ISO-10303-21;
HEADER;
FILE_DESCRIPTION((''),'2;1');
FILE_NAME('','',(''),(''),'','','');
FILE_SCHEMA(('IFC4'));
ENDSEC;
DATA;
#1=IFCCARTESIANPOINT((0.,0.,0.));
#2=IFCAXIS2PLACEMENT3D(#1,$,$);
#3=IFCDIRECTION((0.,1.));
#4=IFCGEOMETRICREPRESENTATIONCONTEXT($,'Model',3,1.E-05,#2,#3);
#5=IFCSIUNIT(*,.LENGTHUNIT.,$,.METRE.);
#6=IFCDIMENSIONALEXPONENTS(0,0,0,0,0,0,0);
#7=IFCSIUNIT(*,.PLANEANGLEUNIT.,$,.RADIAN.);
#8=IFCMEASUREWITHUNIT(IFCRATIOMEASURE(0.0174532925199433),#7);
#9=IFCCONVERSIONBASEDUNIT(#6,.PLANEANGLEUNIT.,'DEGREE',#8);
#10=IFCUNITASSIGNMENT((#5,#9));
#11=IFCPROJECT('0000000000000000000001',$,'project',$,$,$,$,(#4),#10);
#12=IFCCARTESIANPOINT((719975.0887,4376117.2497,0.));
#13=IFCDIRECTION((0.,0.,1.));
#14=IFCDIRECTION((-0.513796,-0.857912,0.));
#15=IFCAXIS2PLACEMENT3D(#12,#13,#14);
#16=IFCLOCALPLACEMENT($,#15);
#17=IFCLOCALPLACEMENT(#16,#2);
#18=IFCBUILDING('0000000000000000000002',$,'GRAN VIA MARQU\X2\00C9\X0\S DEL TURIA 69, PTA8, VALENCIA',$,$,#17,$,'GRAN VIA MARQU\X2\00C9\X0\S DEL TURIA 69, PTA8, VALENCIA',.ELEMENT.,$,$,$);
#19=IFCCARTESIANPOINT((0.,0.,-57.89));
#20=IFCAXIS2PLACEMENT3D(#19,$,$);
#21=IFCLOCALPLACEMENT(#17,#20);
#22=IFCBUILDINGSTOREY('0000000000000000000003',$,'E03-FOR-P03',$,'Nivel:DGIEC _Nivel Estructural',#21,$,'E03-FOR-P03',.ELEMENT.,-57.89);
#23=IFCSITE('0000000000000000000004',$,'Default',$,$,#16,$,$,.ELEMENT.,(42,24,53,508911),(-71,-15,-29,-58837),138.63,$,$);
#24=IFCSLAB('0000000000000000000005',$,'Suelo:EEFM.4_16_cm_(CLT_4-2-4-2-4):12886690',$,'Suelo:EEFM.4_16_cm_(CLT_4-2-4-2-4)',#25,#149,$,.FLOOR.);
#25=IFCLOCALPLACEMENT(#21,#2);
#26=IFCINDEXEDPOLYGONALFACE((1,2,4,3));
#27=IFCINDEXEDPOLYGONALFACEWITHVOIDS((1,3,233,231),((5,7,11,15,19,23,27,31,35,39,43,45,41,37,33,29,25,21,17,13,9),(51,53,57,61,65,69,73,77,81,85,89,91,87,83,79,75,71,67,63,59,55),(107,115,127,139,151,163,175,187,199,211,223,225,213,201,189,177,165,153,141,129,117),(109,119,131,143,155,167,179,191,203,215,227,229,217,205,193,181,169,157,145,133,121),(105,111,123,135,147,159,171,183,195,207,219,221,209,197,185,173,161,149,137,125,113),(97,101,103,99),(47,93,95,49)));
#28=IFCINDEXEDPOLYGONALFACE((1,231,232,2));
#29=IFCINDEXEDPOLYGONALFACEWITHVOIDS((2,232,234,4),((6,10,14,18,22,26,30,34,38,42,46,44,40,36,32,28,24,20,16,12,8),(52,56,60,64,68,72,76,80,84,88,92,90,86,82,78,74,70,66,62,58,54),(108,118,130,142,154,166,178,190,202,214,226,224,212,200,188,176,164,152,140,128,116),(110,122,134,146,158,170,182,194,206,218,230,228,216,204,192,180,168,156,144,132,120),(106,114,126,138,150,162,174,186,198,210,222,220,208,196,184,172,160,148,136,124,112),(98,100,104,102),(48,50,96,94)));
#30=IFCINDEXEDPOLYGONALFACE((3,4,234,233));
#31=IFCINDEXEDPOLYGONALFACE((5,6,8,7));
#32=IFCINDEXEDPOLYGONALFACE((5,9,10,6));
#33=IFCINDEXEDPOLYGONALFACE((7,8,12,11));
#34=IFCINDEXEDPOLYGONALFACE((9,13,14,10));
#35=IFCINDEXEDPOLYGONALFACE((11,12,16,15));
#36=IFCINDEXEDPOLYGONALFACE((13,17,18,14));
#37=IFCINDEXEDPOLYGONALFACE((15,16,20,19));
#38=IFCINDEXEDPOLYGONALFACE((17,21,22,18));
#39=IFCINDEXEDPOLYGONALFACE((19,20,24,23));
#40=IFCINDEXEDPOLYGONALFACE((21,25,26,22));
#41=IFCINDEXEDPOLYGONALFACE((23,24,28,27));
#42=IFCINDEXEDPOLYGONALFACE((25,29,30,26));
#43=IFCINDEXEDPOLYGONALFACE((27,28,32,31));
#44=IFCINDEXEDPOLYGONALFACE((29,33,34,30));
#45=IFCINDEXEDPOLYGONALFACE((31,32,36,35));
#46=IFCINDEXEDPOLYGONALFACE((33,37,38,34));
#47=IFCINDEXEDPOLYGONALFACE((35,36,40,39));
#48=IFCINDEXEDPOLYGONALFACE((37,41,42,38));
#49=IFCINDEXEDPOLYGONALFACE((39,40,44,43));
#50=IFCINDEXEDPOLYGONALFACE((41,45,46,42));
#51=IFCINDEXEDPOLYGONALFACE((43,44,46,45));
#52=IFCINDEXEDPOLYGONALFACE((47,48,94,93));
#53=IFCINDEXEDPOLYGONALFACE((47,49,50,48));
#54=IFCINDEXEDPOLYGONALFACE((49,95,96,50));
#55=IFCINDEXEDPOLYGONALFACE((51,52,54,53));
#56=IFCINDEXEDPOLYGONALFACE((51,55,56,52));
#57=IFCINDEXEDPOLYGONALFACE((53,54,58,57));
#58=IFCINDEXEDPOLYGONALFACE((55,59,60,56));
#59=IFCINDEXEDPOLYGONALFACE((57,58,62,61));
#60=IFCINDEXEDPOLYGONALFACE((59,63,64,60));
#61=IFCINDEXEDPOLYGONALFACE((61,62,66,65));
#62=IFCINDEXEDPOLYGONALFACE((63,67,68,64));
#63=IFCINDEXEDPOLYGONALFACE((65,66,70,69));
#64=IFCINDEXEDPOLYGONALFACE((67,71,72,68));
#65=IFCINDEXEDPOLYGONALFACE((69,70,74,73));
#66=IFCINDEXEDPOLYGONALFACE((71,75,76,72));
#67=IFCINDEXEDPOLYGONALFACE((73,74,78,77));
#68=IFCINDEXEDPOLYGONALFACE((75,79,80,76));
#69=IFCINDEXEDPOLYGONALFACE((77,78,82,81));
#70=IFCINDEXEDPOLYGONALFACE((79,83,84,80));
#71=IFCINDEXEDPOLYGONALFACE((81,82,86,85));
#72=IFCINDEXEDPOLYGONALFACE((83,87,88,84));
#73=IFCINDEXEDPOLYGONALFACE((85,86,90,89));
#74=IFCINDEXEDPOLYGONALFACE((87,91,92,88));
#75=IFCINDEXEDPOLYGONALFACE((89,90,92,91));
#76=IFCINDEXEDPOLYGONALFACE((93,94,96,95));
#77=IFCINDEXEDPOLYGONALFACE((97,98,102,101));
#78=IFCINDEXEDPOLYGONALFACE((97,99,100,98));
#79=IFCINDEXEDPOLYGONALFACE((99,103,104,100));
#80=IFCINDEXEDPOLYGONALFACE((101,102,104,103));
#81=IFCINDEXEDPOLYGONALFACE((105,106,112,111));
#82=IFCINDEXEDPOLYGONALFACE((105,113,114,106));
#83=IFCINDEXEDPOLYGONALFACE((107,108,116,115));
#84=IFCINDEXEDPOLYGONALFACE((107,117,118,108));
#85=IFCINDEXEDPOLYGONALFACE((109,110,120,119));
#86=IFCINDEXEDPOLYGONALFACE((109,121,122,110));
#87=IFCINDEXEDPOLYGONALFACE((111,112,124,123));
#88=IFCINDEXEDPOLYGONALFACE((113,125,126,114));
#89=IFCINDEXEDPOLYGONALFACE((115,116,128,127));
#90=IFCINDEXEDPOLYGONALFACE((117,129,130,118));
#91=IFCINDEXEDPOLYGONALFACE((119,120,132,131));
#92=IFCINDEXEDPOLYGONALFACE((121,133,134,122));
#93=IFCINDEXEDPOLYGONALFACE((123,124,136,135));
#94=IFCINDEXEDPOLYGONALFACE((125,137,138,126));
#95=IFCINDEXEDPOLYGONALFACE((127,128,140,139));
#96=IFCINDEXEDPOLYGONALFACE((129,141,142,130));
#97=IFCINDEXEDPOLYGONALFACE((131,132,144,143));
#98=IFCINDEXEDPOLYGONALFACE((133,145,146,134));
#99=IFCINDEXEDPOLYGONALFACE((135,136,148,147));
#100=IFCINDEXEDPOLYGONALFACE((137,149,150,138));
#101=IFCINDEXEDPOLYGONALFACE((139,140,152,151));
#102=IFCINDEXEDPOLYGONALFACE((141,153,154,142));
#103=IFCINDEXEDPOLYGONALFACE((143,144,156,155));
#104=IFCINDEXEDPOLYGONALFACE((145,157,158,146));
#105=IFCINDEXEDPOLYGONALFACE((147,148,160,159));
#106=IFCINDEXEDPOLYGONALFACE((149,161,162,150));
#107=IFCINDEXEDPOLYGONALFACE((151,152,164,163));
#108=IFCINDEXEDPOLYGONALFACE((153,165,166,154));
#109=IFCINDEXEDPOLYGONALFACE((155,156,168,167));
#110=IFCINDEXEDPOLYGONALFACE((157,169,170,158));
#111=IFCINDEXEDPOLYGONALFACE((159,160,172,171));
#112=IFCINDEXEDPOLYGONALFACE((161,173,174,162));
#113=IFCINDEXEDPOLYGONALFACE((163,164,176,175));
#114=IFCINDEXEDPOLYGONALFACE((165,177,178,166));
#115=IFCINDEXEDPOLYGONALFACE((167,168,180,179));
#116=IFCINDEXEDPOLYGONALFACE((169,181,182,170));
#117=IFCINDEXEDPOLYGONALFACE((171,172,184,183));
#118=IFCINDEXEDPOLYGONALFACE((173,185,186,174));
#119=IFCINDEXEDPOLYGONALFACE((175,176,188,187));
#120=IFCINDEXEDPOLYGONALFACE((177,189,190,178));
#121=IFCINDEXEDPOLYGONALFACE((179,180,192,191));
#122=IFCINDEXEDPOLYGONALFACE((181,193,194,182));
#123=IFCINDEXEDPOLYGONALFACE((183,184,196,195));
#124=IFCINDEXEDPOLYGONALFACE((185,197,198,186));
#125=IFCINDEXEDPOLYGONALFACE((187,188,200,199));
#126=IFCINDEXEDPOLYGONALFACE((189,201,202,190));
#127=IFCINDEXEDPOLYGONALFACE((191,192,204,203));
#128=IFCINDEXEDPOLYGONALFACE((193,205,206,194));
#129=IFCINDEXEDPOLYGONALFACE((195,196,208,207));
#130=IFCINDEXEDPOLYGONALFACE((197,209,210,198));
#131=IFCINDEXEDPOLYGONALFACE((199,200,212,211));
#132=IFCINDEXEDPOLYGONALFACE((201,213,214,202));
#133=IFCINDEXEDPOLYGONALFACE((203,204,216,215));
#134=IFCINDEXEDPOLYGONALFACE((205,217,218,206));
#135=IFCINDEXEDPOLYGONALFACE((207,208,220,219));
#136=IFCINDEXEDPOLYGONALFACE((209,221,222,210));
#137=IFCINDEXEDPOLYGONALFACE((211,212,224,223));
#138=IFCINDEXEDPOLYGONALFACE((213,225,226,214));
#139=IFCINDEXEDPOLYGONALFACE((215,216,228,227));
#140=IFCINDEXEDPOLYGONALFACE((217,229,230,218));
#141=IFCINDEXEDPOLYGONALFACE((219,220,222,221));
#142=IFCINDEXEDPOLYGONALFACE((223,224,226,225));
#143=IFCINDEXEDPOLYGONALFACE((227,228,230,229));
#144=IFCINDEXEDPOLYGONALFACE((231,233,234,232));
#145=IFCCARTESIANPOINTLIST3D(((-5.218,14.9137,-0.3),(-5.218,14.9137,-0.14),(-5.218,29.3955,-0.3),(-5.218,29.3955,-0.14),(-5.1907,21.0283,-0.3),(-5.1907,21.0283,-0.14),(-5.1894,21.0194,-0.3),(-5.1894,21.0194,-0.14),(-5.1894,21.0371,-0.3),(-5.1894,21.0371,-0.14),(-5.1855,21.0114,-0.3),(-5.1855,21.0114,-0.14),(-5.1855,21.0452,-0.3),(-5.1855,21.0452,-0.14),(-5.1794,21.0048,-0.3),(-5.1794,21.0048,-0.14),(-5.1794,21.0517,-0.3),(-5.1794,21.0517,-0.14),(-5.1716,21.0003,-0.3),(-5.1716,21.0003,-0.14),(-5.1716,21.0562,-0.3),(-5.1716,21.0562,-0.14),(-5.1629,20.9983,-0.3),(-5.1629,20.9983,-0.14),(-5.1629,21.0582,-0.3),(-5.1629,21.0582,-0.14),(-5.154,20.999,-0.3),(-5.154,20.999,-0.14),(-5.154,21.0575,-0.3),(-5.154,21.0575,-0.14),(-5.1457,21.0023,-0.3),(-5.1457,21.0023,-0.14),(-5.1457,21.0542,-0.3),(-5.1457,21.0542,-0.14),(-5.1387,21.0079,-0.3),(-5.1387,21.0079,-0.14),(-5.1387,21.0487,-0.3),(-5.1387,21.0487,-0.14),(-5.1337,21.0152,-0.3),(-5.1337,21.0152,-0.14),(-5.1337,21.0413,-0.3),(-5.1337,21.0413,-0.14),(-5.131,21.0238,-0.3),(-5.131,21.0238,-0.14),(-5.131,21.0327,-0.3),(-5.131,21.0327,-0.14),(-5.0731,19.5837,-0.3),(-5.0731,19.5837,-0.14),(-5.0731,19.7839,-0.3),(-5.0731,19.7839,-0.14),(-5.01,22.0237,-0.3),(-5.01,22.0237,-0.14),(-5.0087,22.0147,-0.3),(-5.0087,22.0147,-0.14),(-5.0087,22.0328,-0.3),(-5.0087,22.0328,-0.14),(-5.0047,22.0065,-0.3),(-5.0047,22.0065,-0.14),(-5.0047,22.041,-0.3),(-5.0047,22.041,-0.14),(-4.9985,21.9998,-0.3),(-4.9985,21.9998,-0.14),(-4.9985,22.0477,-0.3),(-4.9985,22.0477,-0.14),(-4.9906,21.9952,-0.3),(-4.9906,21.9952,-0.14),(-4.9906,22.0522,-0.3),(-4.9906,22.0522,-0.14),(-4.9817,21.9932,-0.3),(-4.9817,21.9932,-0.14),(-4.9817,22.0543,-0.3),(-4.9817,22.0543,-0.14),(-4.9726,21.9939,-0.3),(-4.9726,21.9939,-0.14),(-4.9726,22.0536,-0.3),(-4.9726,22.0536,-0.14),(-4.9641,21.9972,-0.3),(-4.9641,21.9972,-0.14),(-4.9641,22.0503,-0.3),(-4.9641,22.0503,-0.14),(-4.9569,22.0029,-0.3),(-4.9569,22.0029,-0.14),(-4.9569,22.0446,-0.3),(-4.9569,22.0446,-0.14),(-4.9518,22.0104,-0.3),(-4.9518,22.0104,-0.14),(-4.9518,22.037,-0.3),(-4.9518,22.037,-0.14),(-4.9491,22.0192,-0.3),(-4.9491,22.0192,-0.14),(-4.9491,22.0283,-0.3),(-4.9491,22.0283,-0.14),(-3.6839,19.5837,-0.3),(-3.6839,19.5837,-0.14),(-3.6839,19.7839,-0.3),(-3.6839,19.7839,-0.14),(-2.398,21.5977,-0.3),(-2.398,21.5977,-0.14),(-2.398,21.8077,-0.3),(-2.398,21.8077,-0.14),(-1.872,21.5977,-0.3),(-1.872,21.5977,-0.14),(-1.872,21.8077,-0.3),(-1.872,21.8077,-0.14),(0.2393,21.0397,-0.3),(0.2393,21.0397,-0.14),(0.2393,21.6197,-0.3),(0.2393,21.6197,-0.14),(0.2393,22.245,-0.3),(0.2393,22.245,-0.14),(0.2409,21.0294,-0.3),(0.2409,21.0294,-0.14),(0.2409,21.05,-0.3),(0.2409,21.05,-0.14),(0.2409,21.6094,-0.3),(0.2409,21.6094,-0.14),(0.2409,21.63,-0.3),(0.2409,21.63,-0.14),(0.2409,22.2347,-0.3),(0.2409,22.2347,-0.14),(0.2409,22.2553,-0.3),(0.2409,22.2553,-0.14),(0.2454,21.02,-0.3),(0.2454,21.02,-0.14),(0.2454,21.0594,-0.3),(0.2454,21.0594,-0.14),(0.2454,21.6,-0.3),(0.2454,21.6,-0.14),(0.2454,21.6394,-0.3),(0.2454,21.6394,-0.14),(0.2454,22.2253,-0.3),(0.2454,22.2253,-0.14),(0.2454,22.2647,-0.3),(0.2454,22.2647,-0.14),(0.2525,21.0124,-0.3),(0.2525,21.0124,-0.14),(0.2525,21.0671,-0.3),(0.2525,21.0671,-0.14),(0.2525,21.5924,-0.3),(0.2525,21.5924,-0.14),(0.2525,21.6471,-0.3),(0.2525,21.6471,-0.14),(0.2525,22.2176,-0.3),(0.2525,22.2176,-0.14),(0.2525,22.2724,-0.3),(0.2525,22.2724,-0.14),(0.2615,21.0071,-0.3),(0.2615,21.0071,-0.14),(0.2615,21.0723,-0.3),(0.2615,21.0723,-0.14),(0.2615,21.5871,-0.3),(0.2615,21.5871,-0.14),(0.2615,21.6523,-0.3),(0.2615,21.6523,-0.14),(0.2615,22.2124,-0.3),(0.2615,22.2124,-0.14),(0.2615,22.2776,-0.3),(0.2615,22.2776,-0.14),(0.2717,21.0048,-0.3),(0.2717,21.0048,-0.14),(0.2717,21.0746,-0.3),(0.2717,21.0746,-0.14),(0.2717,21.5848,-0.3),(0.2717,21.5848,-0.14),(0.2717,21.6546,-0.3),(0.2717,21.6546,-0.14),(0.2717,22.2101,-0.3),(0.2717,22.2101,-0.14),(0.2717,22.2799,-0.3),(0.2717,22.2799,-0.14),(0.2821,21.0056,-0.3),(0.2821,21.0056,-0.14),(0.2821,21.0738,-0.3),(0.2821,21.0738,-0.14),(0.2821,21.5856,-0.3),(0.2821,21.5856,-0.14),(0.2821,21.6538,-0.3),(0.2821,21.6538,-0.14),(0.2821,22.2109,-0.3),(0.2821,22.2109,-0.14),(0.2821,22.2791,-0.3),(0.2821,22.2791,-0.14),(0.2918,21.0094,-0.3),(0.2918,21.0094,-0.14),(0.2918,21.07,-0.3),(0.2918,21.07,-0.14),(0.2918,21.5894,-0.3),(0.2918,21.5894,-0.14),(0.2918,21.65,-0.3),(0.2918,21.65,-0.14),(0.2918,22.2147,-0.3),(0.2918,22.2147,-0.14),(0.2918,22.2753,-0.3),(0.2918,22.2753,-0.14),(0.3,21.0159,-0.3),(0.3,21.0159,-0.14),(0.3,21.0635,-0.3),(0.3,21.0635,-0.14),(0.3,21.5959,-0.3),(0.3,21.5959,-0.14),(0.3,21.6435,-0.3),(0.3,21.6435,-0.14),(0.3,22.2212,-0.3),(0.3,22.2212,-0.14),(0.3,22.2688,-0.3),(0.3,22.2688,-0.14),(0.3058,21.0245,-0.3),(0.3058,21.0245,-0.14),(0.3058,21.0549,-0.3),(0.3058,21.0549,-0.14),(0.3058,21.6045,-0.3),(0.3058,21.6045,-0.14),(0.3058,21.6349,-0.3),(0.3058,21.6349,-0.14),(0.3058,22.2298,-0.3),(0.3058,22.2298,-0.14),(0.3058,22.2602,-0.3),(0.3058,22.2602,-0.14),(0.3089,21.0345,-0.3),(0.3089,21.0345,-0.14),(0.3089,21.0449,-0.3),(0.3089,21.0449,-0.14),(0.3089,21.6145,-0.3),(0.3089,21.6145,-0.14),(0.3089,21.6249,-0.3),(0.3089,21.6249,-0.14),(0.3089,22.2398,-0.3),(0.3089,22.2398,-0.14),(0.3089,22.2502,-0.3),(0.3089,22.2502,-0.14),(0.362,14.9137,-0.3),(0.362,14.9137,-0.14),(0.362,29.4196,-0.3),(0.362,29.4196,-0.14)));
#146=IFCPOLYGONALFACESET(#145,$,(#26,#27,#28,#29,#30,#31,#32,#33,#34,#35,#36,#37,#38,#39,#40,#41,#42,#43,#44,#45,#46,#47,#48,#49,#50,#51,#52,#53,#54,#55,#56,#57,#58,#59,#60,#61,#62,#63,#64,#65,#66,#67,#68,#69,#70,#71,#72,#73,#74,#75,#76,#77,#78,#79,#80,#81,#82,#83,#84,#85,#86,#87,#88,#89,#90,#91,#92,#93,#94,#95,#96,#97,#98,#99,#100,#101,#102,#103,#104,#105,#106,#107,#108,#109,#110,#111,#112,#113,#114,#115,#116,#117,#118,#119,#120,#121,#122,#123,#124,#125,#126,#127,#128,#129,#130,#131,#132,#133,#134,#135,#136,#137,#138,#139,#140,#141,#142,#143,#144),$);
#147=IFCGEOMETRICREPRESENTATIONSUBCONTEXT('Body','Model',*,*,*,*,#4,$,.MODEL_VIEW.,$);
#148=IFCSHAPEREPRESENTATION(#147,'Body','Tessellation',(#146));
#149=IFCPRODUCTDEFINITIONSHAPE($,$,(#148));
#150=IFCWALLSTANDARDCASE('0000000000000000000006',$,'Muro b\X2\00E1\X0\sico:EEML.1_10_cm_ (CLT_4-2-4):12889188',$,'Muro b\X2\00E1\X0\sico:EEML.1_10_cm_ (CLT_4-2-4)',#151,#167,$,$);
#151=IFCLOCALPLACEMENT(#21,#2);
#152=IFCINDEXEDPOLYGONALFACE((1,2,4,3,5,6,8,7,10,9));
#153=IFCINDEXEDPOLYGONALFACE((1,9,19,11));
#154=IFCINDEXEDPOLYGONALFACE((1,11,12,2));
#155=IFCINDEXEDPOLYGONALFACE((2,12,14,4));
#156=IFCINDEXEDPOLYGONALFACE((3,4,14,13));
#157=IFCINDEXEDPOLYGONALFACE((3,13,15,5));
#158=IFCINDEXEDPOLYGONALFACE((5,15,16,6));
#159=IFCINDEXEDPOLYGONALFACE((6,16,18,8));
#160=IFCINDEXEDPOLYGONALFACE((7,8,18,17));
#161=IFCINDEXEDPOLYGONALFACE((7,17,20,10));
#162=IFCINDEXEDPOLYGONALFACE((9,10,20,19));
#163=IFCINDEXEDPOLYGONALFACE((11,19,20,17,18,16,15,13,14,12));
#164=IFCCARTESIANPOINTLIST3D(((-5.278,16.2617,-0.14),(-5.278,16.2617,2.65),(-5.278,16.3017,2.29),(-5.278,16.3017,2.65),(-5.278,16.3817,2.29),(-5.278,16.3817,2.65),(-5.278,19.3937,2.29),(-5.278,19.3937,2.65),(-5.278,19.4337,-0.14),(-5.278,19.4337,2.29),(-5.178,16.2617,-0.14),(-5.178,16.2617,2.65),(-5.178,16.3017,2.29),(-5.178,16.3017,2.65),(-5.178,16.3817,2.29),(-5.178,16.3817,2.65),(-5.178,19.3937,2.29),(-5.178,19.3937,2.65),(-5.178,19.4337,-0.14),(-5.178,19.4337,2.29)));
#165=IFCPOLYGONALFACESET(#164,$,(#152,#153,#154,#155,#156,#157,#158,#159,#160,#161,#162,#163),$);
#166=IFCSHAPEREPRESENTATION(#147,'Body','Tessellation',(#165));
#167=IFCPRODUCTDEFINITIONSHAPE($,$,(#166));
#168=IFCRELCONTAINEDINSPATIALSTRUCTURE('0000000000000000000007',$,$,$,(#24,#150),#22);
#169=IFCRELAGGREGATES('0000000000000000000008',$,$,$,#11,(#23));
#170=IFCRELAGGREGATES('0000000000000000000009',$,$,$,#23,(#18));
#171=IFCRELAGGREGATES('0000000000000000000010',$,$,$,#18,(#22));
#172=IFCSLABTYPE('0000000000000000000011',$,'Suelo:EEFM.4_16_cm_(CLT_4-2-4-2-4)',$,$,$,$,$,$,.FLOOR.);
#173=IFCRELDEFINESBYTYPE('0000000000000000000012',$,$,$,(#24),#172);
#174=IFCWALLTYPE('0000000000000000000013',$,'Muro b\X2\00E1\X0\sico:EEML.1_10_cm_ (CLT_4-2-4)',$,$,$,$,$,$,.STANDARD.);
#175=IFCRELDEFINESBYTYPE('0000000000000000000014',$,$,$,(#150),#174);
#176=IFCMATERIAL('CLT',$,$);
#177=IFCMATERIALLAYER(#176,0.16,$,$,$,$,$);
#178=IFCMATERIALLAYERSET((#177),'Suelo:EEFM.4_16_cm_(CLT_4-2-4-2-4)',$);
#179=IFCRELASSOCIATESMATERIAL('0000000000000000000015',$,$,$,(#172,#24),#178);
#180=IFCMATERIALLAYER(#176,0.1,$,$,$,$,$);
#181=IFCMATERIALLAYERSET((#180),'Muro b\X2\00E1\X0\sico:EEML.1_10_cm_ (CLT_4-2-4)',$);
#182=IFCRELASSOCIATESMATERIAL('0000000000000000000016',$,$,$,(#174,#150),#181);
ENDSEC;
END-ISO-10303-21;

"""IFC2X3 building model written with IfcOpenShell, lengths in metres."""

from ifc_helpers import new_model, entity, si_unit, converted_unit, direction, frame, frame_2d, origin, origin_2d_with_axis, place, context, subcontext, project, spatial, polyline, rectangle, circle, outline, extrude, material, layer, layer_set, layer_usage, type_object, element, save


model = new_model("IFC2X3")

# Units and contexts
model_context = context("Model", 3, precision=1e-05, world=origin(), true_north=direction((0.0, 1.0)))
body_context = subcontext(model_context, "Body", "Model", "MODEL_VIEW")
ifc_project = project(units=[si_unit("LENGTHUNIT", "METRE"), converted_unit("PLANEANGLEUNIT", "DEGREE", entity("IfcRatioMeasure", 0.0174532925199433), si_unit("PLANEANGLEUNIT", "RADIAN"), dimensions=[0, 0, 0, 0, 0, 0, 0])], contexts=[model_context])

# Site, building, storey
site_placement = place(None, frame((719975.0887, 4376117.2497, 0.0), z_axis=(0.0, 0.0, 1.0), x_axis=(-0.513796, -0.857912, 0.0)))
site = spatial("IfcSite", under=ifc_project, at=site_placement, Name="Default", CompositionType="ELEMENT", RefLatitude=(42, 24, 53, 508911), RefLongitude=(-71, -15, -29, -58837), RefElevation=138.63)
building_placement = place(site_placement, origin())
building = spatial("IfcBuilding", under=site, at=building_placement, Name="GRAN VIA MARQUÉS DEL TURIA 69, PTA8, VALENCIA", LongName="GRAN VIA MARQUÉS DEL TURIA 69, PTA8, VALENCIA", CompositionType="ELEMENT")
storey_placement = place(building_placement, frame((0.0, 0.0, -57.89)))
storey = spatial("IfcBuildingStorey", under=building, at=storey_placement, Name="E03-FOR-P03", ObjectType="Nivel:DGIEC _Nivel Estructural", LongName="E03-FOR-P03", CompositionType="ELEMENT", Elevation=-57.89)

# Slab, openings
ifc_material = material(Name="CLT")
ifc_layer_1 = layer(ifc_material, 0.16)
ifc_layer_set_1 = layer_set([ifc_layer_1], Name="Suelo:EEFM.4_16_cm_(CLT_4-2-4-2-4)")
ifc_layer_usage_1 = layer_usage(ifc_layer_set_1, "AXIS3", "POSITIVE", 0.0)
slab_type_1 = type_object("IfcSlabType", Name="Suelo:EEFM.4_16_cm_(CLT_4-2-4-2-4)", PredefinedType="FLOOR", material=ifc_layer_set_1)
slab_1_placement = place(storey_placement, frame((-5.218, 14.9137, -0.3)))
slab_1 = element("IfcSlab", 1, at=slab_1_placement, inside=storey, type_object=slab_type_1, material=ifc_layer_usage_1, Name="Suelo:EEFM.4_16_cm_(CLT_4-2-4-2-4):12886690", ObjectType="Suelo:EEFM.4_16_cm_(CLT_4-2-4-2-4)", PredefinedType="FLOOR", context=body_context, shape_type="SweptSolid", body=[
    extrude(outline(polyline([(-2.79, 7.2529), (-2.79, -7.2529), (2.79, -7.2529), (2.79, 7.2288), (-2.79, 7.2529)])), frame((2.79, 7.2529, 0.16), z_axis=(0.0, 0.0, -1.0), x_axis=(-1.0, 0.0, 0.0)), (0.0, 0.0, 1.0), 0.16),
])
opening_1_placement = place(storey_placement, frame((-5.218, 14.9137, -0.3)))
element("IfcOpeningElement", 2, at=opening_1_placement, cuts=slab_1, ObjectType="Opening", context=body_context, shape_type="SweptSolid", body=[
    extrude(rectangle(XDim=0.2002, YDim=1.3893, at=frame_2d((1.9505, -2.4829), x_axis=(0.0, -1.0))), frame((2.79, 7.2529, 0.16), z_axis=(0.0, 0.0, -1.0), x_axis=(-1.0, 0.0, 0.0)), (0.0, 0.0, 1.0), 0.16),
])
opening_2_placement = place(storey_placement, frame((-5.218, 14.9137, -0.3)))
element("IfcOpeningElement", 3, at=opening_2_placement, cuts=slab_1, ObjectType="Opening", context=body_context, shape_type="SweptSolid", body=[
    extrude(rectangle(XDim=0.21, YDim=0.5259, at=frame_2d((-0.293, -0.4639), x_axis=(0.0, -1.0))), frame((2.79, 7.2529, 0.16), z_axis=(0.0, 0.0, -1.0), x_axis=(-1.0, 0.0, 0.0)), (0.0, 0.0, 1.0), 0.16),
])
opening_3_placement = place(storey_placement, frame((-5.218, 14.9137, -0.3)))
element("IfcOpeningElement", 4, at=opening_3_placement, cuts=slab_1, ObjectType="Opening", context=body_context, shape_type="SweptSolid", body=[
    extrude(circle(Radius=0.03, at=frame_2d((2.7326, -1.1384), x_axis=(1.0, 0.0))), frame((2.79, 7.2529, 0.16), z_axis=(0.0, 0.0, -1.0), x_axis=(-1.0, 0.0, 0.0)), (0.0, 0.0, 1.0), 0.16),
])
opening_4_placement = place(storey_placement, frame((-5.218, 14.9137, -0.3)))
element("IfcOpeningElement", 5, at=opening_4_placement, cuts=slab_1, ObjectType="Opening", context=body_context, shape_type="SweptSolid", body=[
    extrude(circle(Radius=0.035, at=frame_2d((-2.7024, 0.0784), x_axis=(1.0, 0.0))), frame((2.79, 7.2529, 0.16), z_axis=(0.0, 0.0, -1.0), x_axis=(-1.0, 0.0, 0.0)), (0.0, 0.0, 1.0), 0.16),
])
opening_5_placement = place(storey_placement, frame((-5.218, 14.9137, -0.3)))
element("IfcOpeningElement", 6, at=opening_5_placement, cuts=slab_1, ObjectType="Opening", context=body_context, shape_type="SweptSolid", body=[
    extrude(circle(Radius=0.035, at=frame_2d((-2.7024, -0.5469), x_axis=(1.0, 0.0))), frame((2.79, 7.2529, 0.16), z_axis=(0.0, 0.0, -1.0), x_axis=(-1.0, 0.0, 0.0)), (0.0, 0.0, 1.0), 0.16),
])
opening_6_placement = place(storey_placement, frame((-5.218, 14.9137, -0.3)))
element("IfcOpeningElement", 7, at=opening_6_placement, cuts=slab_1, ObjectType="Opening", context=body_context, shape_type="SweptSolid", body=[
    extrude(circle(Radius=0.035, at=frame_2d((-2.7024, -1.1269), x_axis=(1.0, 0.0))), frame((2.79, 7.2529, 0.16), z_axis=(0.0, 0.0, -1.0), x_axis=(-1.0, 0.0, 0.0)), (0.0, 0.0, 1.0), 0.16),
])
opening_7_placement = place(storey_placement, frame((-5.218, 14.9137, -0.3)))
element("IfcOpeningElement", 8, at=opening_7_placement, cuts=slab_1, ObjectType="Opening", context=body_context, shape_type="SweptSolid", body=[
    extrude(circle(Radius=0.0306, at=frame_2d((2.5513, -0.1429), x_axis=(1.0, 0.0))), frame((2.79, 7.2529, 0.16), z_axis=(0.0, 0.0, -1.0), x_axis=(-1.0, 0.0, 0.0)), (0.0, 0.0, 1.0), 0.16),
])

# Wall, openings
ifc_layer_2 = layer(ifc_material, 0.1)
ifc_layer_set_2 = layer_set([ifc_layer_2], Name="Muro básico:EEML.1_10_cm_ (CLT_4-2-4)")
ifc_layer_usage_2 = layer_usage(ifc_layer_set_2, "AXIS2", "NEGATIVE", 0.05)
wall_type_1 = type_object("IfcWallType", Name="Muro básico:EEML.1_10_cm_ (CLT_4-2-4)", PredefinedType="STANDARD", material=ifc_layer_set_2)
wall_1_placement = place(storey_placement, frame((-5.228, 16.2617, -0.14), z_axis=(0.0, 0.0, 1.0), x_axis=(0.0, 1.0, 0.0)))
wall_1 = element("IfcWallStandardCase", 9, at=wall_1_placement, inside=storey, type_object=wall_type_1, material=ifc_layer_usage_2, Name="Muro básico:EEML.1_10_cm_ (CLT_4-2-4):12889188", ObjectType="Muro básico:EEML.1_10_cm_ (CLT_4-2-4)", context=body_context, shape_type="SweptSolid", body=[
    extrude(rectangle(XDim=3.172, YDim=0.1, at=frame_2d((1.586, 0.0), x_axis=(-1.0, 0.0))), origin(), (0.0, 0.0, 1.0), 2.79),
])
opening_8_placement = place(wall_1_placement, origin())
element("IfcOpeningElement", 10, at=opening_8_placement, cuts=wall_1, ObjectType="Opening", context=body_context, shape_type="SweptSolid", body=[
    extrude(rectangle(XDim=0.36, YDim=0.08, at=origin_2d_with_axis()), frame((3.172, 0.05, 2.61), z_axis=(0.0, -1.0, 0.0), x_axis=(0.0, 0.0, 1.0)), (0.0, 0.0, 1.0), 0.1),
])
opening_9_placement = place(wall_1_placement, origin())
element("IfcOpeningElement", 11, at=opening_9_placement, cuts=wall_1, ObjectType="Opening", context=body_context, shape_type="SweptSolid", body=[
    extrude(rectangle(XDim=0.36, YDim=0.08, at=frame_2d((0.0, 0.0), x_axis=(0.0, 1.0))), frame((0.08, 0.05, 2.61), z_axis=(0.0, -1.0, 0.0), x_axis=(-1.0, 0.0, 0.0)), (0.0, 0.0, 1.0), 0.1),
])

save(model, "model.ifc")
